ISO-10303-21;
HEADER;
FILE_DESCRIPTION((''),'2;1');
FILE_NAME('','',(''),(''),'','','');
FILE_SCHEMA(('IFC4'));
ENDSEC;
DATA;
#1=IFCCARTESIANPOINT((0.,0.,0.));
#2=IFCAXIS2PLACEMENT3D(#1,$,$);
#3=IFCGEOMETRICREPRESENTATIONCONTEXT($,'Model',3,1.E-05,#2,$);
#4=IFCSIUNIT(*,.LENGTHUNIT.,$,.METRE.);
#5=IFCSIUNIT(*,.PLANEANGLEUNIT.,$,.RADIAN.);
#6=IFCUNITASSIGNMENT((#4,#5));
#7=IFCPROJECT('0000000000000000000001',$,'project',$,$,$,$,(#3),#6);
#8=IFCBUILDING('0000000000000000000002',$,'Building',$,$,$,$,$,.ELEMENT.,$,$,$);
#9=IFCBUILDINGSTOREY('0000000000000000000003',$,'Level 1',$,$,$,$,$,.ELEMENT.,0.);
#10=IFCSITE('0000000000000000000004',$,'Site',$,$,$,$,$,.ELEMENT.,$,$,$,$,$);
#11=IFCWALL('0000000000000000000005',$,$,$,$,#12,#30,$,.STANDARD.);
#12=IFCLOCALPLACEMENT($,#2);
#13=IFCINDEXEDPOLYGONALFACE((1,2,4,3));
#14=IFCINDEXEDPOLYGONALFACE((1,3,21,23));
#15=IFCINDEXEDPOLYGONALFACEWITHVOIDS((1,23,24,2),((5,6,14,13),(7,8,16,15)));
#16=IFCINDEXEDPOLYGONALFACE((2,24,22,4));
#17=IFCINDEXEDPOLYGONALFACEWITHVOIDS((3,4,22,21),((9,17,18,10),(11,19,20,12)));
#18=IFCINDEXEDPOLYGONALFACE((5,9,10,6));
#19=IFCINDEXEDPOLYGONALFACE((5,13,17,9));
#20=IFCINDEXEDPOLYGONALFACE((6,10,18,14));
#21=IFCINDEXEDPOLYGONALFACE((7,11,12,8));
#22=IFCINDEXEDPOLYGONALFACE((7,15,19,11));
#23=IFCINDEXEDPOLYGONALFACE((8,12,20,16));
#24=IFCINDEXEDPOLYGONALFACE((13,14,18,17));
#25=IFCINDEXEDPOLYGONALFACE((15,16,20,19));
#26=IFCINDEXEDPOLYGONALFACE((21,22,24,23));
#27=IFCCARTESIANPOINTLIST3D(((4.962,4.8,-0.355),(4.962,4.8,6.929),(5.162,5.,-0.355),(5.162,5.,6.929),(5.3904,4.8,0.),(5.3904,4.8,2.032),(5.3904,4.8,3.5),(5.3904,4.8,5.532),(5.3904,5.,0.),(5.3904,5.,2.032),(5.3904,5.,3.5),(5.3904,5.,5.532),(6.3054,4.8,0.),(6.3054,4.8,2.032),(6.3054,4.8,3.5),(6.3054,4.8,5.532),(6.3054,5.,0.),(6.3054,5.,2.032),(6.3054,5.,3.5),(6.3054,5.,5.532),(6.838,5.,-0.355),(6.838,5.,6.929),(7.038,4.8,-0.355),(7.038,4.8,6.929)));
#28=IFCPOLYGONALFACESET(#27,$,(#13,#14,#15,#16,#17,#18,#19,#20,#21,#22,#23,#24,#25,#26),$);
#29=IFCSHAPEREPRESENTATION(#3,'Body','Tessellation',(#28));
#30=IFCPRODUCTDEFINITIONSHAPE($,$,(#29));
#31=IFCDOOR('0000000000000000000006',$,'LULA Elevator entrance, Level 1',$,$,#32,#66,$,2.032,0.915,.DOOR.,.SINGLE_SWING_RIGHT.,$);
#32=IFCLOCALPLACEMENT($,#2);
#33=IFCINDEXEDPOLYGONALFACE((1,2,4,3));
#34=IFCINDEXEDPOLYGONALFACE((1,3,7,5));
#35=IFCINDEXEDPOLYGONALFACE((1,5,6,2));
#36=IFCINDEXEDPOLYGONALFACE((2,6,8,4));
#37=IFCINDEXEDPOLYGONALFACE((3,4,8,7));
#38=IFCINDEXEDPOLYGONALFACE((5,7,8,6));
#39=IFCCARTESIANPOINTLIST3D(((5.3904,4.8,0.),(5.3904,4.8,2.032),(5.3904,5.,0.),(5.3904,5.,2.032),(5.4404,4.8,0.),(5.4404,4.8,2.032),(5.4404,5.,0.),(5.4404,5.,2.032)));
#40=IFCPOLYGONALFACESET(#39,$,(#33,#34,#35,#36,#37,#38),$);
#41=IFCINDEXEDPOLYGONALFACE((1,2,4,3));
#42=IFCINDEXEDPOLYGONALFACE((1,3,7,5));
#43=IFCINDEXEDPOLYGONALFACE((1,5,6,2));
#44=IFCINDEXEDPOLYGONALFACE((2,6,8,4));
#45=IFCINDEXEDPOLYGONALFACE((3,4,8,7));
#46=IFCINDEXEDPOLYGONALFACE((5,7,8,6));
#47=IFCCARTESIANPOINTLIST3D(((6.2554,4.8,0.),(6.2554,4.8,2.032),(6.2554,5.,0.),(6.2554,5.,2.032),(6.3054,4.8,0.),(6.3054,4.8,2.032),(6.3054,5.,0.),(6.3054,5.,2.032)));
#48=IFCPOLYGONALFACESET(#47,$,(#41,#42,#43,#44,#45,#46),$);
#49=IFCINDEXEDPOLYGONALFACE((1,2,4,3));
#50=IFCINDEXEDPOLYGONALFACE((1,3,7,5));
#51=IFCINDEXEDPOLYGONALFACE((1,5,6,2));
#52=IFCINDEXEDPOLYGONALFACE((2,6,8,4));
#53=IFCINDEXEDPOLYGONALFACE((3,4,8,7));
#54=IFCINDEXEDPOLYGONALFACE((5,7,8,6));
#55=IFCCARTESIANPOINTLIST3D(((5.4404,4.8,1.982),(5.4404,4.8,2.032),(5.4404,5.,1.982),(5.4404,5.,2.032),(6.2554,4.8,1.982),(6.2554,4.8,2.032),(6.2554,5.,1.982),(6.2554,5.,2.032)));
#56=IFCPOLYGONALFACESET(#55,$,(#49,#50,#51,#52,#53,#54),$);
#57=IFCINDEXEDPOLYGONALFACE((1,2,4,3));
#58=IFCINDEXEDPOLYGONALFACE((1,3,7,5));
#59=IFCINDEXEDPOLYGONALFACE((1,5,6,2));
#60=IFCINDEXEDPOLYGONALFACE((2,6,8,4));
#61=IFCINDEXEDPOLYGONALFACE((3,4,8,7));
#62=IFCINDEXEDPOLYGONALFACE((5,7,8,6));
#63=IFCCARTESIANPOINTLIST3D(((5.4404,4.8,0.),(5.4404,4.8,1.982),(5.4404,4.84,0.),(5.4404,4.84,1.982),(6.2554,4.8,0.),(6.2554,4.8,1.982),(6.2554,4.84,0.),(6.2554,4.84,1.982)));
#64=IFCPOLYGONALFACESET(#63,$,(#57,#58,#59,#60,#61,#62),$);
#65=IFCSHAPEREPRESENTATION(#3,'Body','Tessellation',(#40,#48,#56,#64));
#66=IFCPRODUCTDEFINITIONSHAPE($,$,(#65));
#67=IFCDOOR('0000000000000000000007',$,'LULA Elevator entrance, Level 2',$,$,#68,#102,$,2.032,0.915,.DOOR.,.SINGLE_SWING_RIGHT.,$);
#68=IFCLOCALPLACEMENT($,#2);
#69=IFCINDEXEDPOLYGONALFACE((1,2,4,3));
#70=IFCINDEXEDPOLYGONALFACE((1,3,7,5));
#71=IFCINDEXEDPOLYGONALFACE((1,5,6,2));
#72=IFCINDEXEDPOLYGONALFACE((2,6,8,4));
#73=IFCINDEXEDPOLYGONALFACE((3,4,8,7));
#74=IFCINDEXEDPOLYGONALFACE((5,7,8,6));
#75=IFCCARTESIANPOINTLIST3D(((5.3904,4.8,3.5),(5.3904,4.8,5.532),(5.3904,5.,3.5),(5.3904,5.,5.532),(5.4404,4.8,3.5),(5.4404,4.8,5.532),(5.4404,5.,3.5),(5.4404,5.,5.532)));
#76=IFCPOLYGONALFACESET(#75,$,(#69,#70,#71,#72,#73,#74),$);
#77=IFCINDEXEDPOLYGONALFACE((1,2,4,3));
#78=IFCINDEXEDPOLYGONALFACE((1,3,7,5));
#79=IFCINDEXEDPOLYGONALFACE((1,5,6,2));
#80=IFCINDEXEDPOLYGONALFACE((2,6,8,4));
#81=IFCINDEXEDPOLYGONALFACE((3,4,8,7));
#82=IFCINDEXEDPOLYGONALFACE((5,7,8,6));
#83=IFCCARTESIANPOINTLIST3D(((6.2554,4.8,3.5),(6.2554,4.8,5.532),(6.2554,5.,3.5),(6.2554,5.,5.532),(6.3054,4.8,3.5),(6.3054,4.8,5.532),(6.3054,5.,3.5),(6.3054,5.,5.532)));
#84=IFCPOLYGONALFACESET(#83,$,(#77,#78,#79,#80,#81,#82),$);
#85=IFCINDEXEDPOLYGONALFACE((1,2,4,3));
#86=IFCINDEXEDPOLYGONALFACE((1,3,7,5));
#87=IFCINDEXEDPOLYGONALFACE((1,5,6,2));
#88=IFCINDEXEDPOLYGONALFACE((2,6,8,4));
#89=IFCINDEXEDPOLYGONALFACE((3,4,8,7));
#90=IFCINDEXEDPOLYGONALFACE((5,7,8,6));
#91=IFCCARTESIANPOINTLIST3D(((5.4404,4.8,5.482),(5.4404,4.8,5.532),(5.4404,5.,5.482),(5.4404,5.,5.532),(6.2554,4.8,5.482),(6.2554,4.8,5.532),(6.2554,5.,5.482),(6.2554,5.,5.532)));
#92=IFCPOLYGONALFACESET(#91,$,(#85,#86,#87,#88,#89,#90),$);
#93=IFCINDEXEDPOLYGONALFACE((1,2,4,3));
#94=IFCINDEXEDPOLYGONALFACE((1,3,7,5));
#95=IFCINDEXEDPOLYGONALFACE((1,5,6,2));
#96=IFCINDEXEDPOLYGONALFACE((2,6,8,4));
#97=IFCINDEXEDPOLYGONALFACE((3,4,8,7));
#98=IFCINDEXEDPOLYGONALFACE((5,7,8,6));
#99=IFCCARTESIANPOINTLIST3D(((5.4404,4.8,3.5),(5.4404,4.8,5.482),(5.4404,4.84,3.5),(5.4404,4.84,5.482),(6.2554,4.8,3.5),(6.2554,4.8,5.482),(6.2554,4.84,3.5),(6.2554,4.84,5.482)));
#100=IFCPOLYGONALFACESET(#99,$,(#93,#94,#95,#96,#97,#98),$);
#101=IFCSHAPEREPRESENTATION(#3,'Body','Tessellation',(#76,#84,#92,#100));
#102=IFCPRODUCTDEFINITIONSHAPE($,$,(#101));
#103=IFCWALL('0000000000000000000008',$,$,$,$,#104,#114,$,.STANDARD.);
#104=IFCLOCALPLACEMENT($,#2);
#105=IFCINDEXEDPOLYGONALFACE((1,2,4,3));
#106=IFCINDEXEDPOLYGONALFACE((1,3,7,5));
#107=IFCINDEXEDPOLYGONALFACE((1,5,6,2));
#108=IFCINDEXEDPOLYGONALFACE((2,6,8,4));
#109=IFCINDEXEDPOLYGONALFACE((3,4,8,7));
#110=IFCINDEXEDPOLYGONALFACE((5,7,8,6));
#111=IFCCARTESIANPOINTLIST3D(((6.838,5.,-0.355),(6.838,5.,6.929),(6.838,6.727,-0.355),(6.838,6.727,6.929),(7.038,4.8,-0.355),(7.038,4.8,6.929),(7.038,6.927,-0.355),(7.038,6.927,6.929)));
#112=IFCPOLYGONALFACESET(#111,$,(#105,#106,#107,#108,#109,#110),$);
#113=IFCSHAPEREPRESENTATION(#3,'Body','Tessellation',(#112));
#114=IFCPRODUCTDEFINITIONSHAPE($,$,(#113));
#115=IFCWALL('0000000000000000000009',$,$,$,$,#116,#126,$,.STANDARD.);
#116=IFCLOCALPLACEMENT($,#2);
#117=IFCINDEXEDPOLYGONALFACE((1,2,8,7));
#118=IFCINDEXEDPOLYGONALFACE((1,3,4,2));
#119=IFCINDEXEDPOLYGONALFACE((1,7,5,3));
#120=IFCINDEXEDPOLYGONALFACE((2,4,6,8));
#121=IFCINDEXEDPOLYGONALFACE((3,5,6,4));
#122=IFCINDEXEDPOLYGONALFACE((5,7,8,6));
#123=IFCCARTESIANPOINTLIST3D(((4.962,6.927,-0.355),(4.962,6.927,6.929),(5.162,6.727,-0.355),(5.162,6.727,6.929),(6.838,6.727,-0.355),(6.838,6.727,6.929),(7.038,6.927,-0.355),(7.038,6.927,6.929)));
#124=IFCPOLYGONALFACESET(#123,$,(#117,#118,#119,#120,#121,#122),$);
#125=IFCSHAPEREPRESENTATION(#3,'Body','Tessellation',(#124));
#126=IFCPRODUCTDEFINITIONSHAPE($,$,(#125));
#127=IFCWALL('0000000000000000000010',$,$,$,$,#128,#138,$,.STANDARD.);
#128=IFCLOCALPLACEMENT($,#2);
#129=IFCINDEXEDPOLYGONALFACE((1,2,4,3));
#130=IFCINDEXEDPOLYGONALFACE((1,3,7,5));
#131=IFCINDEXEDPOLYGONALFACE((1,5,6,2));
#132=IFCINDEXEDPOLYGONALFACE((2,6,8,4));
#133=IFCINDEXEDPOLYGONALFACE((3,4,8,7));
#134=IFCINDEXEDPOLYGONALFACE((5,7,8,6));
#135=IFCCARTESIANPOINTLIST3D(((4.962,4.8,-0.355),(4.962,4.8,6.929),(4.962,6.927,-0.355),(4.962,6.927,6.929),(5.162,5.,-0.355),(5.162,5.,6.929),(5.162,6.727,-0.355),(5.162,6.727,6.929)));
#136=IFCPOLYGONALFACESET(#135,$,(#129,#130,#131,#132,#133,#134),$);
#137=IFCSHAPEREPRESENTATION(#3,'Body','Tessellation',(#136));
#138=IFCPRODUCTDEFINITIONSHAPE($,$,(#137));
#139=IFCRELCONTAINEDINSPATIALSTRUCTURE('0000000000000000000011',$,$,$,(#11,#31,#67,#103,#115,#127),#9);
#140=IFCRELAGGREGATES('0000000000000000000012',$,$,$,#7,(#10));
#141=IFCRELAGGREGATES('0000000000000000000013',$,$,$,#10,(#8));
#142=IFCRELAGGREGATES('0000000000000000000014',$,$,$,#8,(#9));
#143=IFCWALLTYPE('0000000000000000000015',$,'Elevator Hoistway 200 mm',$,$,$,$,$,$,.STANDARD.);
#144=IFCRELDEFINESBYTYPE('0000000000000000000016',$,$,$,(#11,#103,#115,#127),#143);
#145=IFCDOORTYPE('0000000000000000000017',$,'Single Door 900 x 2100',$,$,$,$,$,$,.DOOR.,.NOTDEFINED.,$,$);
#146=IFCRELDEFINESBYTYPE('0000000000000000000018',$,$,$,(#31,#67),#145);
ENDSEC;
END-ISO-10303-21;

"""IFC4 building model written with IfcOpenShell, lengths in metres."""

from ifc_helpers import new_model, si_unit, frame, frame_2d, origin, origin_with_axes, origin_2d, place, context, project, spatial, polyline, rectangle, outline, extrude, type_object, element, fill, save


model = new_model("IFC4")

# Units and contexts
model_context = context("Model", 3, precision=1e-05, world=origin())
ifc_project = project(units=[si_unit("LENGTHUNIT", "METRE"), si_unit("PLANEANGLEUNIT", "RADIAN")], contexts=[model_context])

# Site, building, storey
site = spatial("IfcSite", under=ifc_project, Name="Site", CompositionType="ELEMENT")
building = spatial("IfcBuilding", under=site, Name="Building", CompositionType="ELEMENT")
storey = spatial("IfcBuildingStorey", under=building, Name="Level 1", CompositionType="ELEMENT", Elevation=0.0)

# Shared definitions
wall_type = type_object("IfcWallType", Name="Elevator Hoistway 200 mm", PredefinedType="STANDARD")

# Wall, openings, doors
wall_1_placement = place(None, frame((5.062, 4.9, -0.355), z_axis=(0.0, 0.0, 1.0), x_axis=(1.0, 0.0, 0.0)))
wall_1 = element("IfcWall", 1, at=wall_1_placement, inside=storey, type_object=wall_type, PredefinedType="STANDARD", context=model_context, shape_type="SweptSolid", body=[
    extrude(outline(polyline([(-0.1, -0.1), (1.976, -0.1), (1.776, 0.1), (0.1, 0.1), (-0.1, -0.1)])), origin(), (0.0, 0.0, 1.0), 7.284),
])
opening_1_placement = place(wall_1_placement, frame((0.7859, 0.0, 0.355), z_axis=(0.0, 0.0, 1.0), x_axis=(1.0, 0.0, 0.0)))
opening_1 = element("IfcOpeningElement", 2, at=opening_1_placement, cuts=wall_1, PredefinedType="OPENING", context=model_context, shape_type="SweptSolid", body=[
    extrude(rectangle(XDim=0.915, YDim=0.202, at=origin_2d()), origin(), (0.0, 0.0, 1.0), 2.032),
])
opening_2_placement = place(wall_1_placement, frame((0.7859, 0.0, 3.855), z_axis=(0.0, 0.0, 1.0), x_axis=(1.0, 0.0, 0.0)))
opening_2 = element("IfcOpeningElement", 3, at=opening_2_placement, cuts=wall_1, PredefinedType="OPENING", context=model_context, shape_type="SweptSolid", body=[
    extrude(rectangle(XDim=0.915, YDim=0.202, at=origin_2d()), origin(), (0.0, 0.0, 1.0), 2.032),
])
door_type = type_object("IfcDoorType", Name="Single Door 900 x 2100", OperationType="NOTDEFINED", PredefinedType="DOOR")
door_1_placement = place(opening_1_placement, origin_with_axes())
door_1 = element("IfcDoor", 4, at=door_1_placement, inside=storey, type_object=door_type, Name="LULA Elevator entrance, Level 1", OperationType="SINGLE_SWING_RIGHT", OverallHeight=2.032, OverallWidth=0.915, PredefinedType="DOOR", context=model_context, shape_type="SweptSolid", body=[
    extrude(rectangle(XDim=0.05, YDim=0.2, at=frame_2d((-0.4325, 0.0))), origin(), (0.0, 0.0, 1.0), 2.032),
    extrude(rectangle(XDim=0.05, YDim=0.2, at=frame_2d((0.4325, 0.0))), origin(), (0.0, 0.0, 1.0), 2.032),
    extrude(rectangle(XDim=0.815, YDim=0.2, at=origin_2d()), frame((0.0, 0.0, 1.982)), (0.0, 0.0, 1.0), 0.05),
    extrude(rectangle(XDim=0.815, YDim=0.04, at=frame_2d((0.0, -0.08))), origin(), (0.0, 0.0, 1.0), 1.982),
])
fill(opening_1, door_1)
door_2_placement = place(opening_2_placement, origin_with_axes())
door_2 = element("IfcDoor", 5, at=door_2_placement, inside=storey, type_object=door_type, Name="LULA Elevator entrance, Level 2", OperationType="SINGLE_SWING_RIGHT", OverallHeight=2.032, OverallWidth=0.915, PredefinedType="DOOR", context=model_context, shape_type="SweptSolid", body=[
    extrude(rectangle(XDim=0.05, YDim=0.2, at=frame_2d((-0.4325, 0.0))), origin(), (0.0, 0.0, 1.0), 2.032),
    extrude(rectangle(XDim=0.05, YDim=0.2, at=frame_2d((0.4325, 0.0))), origin(), (0.0, 0.0, 1.0), 2.032),
    extrude(rectangle(XDim=0.815, YDim=0.2, at=origin_2d()), frame((0.0, 0.0, 1.982)), (0.0, 0.0, 1.0), 0.05),
    extrude(rectangle(XDim=0.815, YDim=0.04, at=frame_2d((0.0, -0.08))), origin(), (0.0, 0.0, 1.0), 1.982),
])
fill(opening_2, door_2)

# Walls
wall_2_placement = place(None, frame((6.938, 4.9, -0.355), z_axis=(0.0, 0.0, 1.0), x_axis=(0.0, 1.0, 0.0)))
element("IfcWall", 6, at=wall_2_placement, inside=storey, type_object=wall_type, PredefinedType="STANDARD", context=model_context, shape_type="SweptSolid", body=[
    extrude(outline(polyline([(-0.1, -0.1), (2.027, -0.1), (1.827, 0.1), (0.1, 0.1), (-0.1, -0.1)])), origin(), (0.0, 0.0, 1.0), 7.284),
])
wall_3_placement = place(None, frame((6.938, 6.827, -0.355), z_axis=(0.0, 0.0, 1.0), x_axis=(-1.0, 0.0, 0.0)))
element("IfcWall", 7, at=wall_3_placement, inside=storey, type_object=wall_type, PredefinedType="STANDARD", context=model_context, shape_type="SweptSolid", body=[
    extrude(outline(polyline([(-0.1, -0.1), (1.976, -0.1), (1.776, 0.1), (0.1, 0.1), (-0.1, -0.1)])), origin(), (0.0, 0.0, 1.0), 7.284),
])
wall_4_placement = place(None, frame((5.062, 6.827, -0.355), z_axis=(0.0, 0.0, 1.0), x_axis=(0.0, -1.0, 0.0)))
element("IfcWall", 8, at=wall_4_placement, inside=storey, type_object=wall_type, PredefinedType="STANDARD", context=model_context, shape_type="SweptSolid", body=[
    extrude(outline(polyline([(-0.1, -0.1), (2.027, -0.1), (1.827, 0.1), (0.1, 0.1), (-0.1, -0.1)])), origin(), (0.0, 0.0, 1.0), 7.284),
])

save(model, "model.ifc")
